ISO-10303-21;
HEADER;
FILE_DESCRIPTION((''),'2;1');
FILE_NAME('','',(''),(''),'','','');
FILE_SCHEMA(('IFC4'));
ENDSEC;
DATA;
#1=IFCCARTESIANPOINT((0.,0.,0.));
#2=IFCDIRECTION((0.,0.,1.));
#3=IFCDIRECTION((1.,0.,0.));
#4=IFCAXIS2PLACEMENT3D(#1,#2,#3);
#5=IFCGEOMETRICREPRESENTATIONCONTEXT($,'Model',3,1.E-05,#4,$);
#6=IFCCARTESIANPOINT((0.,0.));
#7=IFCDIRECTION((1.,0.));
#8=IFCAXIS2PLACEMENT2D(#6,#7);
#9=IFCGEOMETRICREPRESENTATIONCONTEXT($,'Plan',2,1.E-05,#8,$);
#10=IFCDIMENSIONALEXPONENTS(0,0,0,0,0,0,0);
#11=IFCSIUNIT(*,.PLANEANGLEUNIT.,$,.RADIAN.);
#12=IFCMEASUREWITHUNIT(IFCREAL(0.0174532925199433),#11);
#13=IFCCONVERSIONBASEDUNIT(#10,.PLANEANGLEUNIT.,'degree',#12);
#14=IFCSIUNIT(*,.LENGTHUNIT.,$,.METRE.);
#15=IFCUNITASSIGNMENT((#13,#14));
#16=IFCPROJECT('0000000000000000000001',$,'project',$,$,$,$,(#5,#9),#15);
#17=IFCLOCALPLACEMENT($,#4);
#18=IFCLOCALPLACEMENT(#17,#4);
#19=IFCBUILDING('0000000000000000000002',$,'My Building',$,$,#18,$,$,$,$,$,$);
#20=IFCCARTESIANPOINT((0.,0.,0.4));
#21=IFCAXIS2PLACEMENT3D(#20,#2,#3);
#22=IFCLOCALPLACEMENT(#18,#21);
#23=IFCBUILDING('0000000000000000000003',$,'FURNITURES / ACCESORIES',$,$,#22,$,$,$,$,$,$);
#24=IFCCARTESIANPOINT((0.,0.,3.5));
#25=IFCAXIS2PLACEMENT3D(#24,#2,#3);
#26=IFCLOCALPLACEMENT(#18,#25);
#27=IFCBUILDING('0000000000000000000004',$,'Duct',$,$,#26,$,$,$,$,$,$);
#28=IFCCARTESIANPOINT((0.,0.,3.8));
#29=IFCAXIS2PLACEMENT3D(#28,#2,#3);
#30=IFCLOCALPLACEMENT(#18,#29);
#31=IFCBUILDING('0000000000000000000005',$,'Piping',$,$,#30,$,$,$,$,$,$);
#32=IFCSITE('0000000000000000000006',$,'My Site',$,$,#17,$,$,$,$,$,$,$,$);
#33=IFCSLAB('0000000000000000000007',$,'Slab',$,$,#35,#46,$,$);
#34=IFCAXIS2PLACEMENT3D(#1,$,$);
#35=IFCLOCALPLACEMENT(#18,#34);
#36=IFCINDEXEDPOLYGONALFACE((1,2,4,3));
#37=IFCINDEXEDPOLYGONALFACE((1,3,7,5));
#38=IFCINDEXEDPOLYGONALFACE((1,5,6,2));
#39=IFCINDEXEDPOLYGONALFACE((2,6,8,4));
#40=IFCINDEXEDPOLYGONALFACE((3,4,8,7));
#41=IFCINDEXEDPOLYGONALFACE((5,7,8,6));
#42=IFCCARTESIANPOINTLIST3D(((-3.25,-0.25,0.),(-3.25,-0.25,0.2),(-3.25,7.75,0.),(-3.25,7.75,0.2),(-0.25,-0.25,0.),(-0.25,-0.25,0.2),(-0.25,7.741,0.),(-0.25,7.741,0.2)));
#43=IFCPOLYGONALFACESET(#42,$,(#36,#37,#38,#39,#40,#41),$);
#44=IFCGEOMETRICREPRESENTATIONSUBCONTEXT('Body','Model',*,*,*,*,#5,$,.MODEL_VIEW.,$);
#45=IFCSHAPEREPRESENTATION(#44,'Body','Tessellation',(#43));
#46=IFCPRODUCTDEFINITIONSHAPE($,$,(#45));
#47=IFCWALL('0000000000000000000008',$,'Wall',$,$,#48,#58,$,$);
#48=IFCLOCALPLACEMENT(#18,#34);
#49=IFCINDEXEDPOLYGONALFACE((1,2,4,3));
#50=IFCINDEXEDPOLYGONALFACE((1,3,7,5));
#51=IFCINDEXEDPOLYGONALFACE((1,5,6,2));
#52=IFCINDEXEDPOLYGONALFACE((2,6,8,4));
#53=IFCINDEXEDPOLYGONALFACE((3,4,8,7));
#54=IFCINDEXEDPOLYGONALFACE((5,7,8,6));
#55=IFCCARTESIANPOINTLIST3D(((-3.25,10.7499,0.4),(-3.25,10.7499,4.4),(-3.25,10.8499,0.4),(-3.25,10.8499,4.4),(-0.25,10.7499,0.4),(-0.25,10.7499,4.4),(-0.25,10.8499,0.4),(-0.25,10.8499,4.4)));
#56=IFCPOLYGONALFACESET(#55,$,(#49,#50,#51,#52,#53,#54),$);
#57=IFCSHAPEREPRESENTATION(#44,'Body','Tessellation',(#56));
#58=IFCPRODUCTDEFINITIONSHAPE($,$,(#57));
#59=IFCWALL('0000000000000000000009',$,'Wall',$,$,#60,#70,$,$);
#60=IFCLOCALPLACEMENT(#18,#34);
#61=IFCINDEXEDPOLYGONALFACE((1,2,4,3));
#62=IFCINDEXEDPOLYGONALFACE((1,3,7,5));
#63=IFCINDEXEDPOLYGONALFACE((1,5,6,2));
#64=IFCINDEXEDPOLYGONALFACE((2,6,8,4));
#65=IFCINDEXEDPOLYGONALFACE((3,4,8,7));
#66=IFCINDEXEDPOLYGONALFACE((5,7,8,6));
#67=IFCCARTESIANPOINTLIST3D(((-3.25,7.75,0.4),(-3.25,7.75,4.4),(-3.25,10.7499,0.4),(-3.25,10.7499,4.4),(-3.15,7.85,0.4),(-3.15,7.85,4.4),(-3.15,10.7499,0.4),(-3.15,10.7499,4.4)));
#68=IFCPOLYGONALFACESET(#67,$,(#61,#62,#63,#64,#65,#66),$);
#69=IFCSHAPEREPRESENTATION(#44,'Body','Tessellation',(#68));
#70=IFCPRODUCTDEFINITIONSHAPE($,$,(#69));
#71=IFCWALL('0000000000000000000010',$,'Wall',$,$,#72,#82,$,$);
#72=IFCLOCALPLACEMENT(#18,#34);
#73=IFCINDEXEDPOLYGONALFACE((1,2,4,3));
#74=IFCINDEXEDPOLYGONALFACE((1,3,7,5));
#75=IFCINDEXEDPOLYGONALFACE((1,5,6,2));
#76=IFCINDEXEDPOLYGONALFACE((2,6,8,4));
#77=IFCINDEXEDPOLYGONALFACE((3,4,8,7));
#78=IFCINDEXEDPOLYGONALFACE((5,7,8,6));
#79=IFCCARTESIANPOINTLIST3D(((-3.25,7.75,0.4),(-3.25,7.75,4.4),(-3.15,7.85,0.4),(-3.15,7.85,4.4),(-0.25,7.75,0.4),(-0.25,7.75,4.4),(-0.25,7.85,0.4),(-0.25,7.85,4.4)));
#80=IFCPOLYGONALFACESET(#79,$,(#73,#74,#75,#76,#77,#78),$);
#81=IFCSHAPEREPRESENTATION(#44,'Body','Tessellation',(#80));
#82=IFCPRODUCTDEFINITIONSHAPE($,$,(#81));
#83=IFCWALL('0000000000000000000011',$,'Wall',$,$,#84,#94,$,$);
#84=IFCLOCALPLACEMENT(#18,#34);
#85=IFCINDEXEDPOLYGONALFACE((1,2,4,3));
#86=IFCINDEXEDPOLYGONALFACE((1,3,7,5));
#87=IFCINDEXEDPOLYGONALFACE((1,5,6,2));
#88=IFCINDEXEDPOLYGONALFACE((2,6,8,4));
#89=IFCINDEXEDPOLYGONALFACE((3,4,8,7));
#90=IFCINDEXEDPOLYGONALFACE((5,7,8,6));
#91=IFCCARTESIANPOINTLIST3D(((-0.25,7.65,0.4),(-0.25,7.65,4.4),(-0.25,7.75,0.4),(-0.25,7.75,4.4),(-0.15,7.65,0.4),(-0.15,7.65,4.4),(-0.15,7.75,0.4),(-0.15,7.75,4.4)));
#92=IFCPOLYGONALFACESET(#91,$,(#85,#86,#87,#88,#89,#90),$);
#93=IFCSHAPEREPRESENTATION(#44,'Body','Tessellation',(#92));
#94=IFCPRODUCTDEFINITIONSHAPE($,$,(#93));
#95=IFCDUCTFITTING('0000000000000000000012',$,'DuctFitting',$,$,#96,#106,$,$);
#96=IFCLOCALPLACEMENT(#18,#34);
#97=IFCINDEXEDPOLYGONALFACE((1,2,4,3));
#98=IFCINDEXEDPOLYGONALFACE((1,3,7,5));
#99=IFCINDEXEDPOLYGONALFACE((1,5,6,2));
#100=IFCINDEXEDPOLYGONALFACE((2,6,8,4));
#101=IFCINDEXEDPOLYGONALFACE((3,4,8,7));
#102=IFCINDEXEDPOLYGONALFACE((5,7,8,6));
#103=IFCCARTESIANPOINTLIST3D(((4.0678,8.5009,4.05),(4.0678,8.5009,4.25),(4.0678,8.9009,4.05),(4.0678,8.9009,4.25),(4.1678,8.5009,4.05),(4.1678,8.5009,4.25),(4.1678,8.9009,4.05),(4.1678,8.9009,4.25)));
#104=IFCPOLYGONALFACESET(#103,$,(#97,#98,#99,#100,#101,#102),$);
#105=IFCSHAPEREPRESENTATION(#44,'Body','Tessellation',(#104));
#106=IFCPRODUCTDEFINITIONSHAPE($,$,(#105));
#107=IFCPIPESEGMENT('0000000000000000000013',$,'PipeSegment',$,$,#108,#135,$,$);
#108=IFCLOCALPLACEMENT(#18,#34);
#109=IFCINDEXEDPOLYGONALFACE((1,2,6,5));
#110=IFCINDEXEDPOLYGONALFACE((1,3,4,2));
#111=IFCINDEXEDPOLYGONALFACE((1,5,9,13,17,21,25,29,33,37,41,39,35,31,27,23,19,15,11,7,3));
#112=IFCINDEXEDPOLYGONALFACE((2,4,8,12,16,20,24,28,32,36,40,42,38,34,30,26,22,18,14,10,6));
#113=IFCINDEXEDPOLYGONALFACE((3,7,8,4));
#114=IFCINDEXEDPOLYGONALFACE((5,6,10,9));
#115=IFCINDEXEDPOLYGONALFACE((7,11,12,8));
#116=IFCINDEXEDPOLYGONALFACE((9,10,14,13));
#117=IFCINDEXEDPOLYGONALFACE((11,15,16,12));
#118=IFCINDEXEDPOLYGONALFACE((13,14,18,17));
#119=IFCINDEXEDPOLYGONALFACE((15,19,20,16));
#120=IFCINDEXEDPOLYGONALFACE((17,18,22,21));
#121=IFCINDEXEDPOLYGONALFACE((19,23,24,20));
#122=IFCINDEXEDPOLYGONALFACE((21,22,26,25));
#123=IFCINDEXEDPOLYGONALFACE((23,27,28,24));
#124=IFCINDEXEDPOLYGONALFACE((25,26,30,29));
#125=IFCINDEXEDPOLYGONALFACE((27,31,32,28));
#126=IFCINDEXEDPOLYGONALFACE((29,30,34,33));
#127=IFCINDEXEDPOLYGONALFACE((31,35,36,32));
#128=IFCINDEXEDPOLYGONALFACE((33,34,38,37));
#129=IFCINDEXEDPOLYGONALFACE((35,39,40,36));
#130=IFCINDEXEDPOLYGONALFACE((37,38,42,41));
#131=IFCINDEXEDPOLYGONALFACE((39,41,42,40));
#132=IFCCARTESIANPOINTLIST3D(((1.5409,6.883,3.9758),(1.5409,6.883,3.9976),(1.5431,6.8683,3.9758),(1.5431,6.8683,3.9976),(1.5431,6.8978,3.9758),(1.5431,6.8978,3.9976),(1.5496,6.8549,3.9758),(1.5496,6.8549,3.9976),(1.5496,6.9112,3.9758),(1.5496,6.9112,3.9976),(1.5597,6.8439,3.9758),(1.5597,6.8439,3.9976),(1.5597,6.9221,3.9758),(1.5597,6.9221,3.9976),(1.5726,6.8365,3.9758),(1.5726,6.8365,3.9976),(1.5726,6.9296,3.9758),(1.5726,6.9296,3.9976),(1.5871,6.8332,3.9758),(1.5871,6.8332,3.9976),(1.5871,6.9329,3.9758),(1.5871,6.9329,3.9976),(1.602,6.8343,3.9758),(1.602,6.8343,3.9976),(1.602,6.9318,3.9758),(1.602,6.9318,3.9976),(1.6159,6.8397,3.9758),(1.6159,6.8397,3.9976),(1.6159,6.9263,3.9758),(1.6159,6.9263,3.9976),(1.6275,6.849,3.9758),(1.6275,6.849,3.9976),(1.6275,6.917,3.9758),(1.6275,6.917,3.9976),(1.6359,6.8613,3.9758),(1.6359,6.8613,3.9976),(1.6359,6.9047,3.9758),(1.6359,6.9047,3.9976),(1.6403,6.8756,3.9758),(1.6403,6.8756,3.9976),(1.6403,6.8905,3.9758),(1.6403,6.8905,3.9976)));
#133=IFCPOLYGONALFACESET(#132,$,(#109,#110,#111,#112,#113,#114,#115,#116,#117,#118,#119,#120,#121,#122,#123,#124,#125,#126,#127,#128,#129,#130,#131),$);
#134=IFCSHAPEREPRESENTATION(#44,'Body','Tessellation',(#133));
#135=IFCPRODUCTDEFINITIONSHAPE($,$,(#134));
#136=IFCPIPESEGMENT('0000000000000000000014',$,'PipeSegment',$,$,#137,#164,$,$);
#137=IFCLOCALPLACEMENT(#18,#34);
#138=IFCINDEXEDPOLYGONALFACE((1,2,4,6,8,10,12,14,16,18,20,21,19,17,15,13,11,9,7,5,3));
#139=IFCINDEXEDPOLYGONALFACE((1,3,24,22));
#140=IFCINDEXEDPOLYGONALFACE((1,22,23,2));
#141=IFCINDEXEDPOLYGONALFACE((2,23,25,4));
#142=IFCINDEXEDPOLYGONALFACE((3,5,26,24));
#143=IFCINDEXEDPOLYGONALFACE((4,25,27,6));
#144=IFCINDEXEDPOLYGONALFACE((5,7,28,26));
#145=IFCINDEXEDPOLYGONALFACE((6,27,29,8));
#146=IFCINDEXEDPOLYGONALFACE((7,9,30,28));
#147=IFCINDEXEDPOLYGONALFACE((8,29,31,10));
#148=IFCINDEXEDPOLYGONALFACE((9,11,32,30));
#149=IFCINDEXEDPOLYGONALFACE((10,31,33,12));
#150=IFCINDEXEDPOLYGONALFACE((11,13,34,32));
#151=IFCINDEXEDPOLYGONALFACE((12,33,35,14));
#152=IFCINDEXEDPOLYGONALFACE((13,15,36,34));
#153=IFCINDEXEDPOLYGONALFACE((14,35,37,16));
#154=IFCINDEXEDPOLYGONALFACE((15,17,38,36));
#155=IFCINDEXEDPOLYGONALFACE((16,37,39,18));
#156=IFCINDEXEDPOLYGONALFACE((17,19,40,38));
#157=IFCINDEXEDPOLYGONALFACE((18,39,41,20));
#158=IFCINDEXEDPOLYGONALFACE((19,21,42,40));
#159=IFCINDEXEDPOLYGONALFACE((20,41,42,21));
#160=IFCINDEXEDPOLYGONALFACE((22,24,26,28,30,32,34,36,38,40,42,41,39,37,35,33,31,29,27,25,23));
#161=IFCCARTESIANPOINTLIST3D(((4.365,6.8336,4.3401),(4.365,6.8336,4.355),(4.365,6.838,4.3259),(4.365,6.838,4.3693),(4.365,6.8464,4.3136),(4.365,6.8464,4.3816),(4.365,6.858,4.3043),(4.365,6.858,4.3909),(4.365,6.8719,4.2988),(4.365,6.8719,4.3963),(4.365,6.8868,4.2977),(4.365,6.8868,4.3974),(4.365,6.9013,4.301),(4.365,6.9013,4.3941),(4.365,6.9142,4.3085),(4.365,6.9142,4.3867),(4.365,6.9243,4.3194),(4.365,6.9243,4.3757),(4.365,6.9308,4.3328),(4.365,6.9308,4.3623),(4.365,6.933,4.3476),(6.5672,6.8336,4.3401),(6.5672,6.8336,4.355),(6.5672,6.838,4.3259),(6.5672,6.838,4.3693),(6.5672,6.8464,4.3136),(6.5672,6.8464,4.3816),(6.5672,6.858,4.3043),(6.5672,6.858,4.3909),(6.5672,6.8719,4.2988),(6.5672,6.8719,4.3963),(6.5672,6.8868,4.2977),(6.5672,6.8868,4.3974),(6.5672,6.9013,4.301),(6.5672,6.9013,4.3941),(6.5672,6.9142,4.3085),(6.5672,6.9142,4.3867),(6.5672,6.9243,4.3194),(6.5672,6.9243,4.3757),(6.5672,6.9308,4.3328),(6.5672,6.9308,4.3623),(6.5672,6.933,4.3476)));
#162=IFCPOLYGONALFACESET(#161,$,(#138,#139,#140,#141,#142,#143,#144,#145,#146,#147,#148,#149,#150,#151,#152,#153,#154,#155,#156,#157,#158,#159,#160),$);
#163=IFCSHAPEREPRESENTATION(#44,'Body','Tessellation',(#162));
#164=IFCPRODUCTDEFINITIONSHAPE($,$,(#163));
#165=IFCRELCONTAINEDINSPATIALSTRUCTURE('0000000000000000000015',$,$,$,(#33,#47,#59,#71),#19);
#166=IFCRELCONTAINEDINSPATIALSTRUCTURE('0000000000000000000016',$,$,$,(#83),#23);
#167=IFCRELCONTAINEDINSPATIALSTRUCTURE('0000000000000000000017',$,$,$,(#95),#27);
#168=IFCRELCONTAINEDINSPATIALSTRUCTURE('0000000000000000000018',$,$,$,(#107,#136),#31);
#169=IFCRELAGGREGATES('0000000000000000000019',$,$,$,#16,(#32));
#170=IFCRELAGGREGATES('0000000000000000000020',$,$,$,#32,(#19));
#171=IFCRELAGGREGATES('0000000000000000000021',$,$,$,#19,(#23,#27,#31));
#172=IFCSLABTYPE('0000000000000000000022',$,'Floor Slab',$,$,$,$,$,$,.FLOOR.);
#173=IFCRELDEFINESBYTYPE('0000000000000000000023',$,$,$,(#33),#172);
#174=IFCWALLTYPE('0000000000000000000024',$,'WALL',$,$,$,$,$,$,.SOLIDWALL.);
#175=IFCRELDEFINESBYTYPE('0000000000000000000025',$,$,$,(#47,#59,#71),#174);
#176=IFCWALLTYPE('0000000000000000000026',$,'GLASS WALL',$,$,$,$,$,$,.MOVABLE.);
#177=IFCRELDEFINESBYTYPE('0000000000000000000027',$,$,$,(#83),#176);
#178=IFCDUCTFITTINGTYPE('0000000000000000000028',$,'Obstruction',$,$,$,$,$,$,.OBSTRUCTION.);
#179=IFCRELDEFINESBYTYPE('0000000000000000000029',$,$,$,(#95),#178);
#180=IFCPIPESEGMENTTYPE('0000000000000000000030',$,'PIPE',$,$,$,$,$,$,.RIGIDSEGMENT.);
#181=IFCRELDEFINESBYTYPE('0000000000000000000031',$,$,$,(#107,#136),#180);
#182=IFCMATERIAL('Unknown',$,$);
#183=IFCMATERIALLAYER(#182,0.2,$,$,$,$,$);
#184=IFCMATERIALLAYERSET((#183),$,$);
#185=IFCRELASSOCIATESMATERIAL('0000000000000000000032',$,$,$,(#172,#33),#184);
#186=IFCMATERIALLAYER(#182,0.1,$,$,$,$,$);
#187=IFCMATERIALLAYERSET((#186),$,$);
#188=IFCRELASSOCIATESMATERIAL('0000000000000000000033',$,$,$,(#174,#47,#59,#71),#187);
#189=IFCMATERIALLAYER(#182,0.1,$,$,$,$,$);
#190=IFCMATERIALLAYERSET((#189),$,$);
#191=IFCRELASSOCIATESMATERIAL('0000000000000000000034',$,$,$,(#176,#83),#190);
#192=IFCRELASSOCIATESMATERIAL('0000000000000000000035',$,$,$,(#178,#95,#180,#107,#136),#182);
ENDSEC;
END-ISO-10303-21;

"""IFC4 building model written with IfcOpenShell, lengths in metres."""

from ifc_helpers import new_model, entity, si_unit, converted_unit, frame, origin_with_axes, origin_2d_with_axis, place, context, subcontext, project, spatial, line, indexed_curve, rectangle, circle, outline, extrude, material, layer, layer_set, layer_usage, material_profile, profile_set, profile_usage, type_object, element, save


model = new_model("IFC4")

# Units and contexts
model_context = context("Model", 3, precision=1e-05, world=origin_with_axes())
plan_context = context("Plan", 2, precision=1e-05, world=origin_2d_with_axis())
body_context = subcontext(model_context, "Body", "Model", "MODEL_VIEW")
ifc_project = project(units=[converted_unit("PLANEANGLEUNIT", "degree", entity("IfcReal", 0.0174532925199433), si_unit("PLANEANGLEUNIT", "RADIAN"), dimensions=[0, 0, 0, 0, 0, 0, 0]), si_unit("LENGTHUNIT", "METRE")], contexts=[model_context, plan_context])

# Site, building
site_placement = place(None, origin_with_axes())
site = spatial("IfcSite", under=ifc_project, at=site_placement, Name="My Site")
building_1_placement = place(site_placement, origin_with_axes())
building_1 = spatial("IfcBuilding", under=site, at=building_1_placement, Name="My Building")

# Slab
ifc_material = material(Name="Unknown")
ifc_layer_1 = layer(ifc_material, 0.2)
ifc_layer_set_1 = layer_set([ifc_layer_1])
ifc_layer_usage_1 = layer_usage(ifc_layer_set_1, "AXIS3", "POSITIVE", -0.2)
slab_type = type_object("IfcSlabType", Name="Floor Slab", PredefinedType="FLOOR", material=ifc_layer_set_1)
slab_placement = place(building_1_placement, frame((-3.25, 7.75, 0.2), z_axis=(0.0, 0.0, 1.0), x_axis=(1.0, 0.0, 0.0)))
element("IfcSlab", 1, at=slab_placement, inside=building_1, type_object=slab_type, material=ifc_layer_usage_1, Name="Slab", context=body_context, shape_type="SweptSolid", body=[
    extrude(outline(indexed_curve([(0.0, 0.0), (3.0, -0.009), (3.0, -8.0), (0.0, -8.0), (0.0, 0.0)])), frame((0.0, 0.0, -0.2), z_axis=(0.0, 0.0, 1.0), x_axis=(1.0, 0.0, 0.0)), (0.0, 0.0, 1.0), 0.2),
])

# Walls
ifc_layer_2 = layer(ifc_material, 0.1)
ifc_layer_set_2 = layer_set([ifc_layer_2])
ifc_layer_usage_2 = layer_usage(ifc_layer_set_2, "AXIS2", "POSITIVE", 0.0)
wall_type_1 = type_object("IfcWallType", Name="WALL", PredefinedType="SOLIDWALL", material=ifc_layer_set_2)
wall_1_placement = place(building_1_placement, frame((-3.25, 10.7499, 0.4), z_axis=(0.0, 0.0, 1.0), x_axis=(1.0, 0.0, 0.0)))
element("IfcWall", 2, at=wall_1_placement, inside=building_1, type_object=wall_type_1, material=ifc_layer_usage_2, Name="Wall", context=body_context, shape_type="SweptSolid", body=[
    extrude(outline(indexed_curve([(0.0, 0.0), (0.0, 0.1), (3.0, 0.1), (3.0, 0.0)], segments=[line(1, 2, 3, 4, 1)])), origin_with_axes(), (0.0, 0.0, 1.0), 4.0),
])
ifc_layer_usage_3 = layer_usage(ifc_layer_set_2, "AXIS2", "POSITIVE", 0.0)
wall_2_placement = place(building_1_placement, frame((-3.25, 10.7499, 0.4), z_axis=(0.0, 0.0, 1.0), x_axis=(0.0, -1.0, 0.0)))
element("IfcWall", 3, at=wall_2_placement, inside=building_1, type_object=wall_type_1, material=ifc_layer_usage_3, Name="Wall", context=body_context, shape_type="SweptSolid", body=[
    extrude(outline(indexed_curve([(0.0, 0.0), (0.0, 0.1), (2.8999, 0.1), (2.9999, 0.0)], segments=[line(1, 2, 3, 4, 1)])), origin_with_axes(), (0.0, 0.0, 1.0), 4.0),
])
ifc_layer_usage_4 = layer_usage(ifc_layer_set_2, "AXIS2", "POSITIVE", 0.0)
wall_3_placement = place(building_1_placement, frame((-3.25, 7.75, 0.4), z_axis=(0.0, 0.0, 1.0), x_axis=(1.0, 0.0, 0.0)))
element("IfcWall", 4, at=wall_3_placement, inside=building_1, type_object=wall_type_1, material=ifc_layer_usage_4, Name="Wall", context=body_context, shape_type="SweptSolid", body=[
    extrude(outline(indexed_curve([(0.0, 0.0), (0.1, 0.1), (3.0, 0.1), (3.0, 0.0)], segments=[line(1, 2, 3, 4, 1)])), origin_with_axes(), (0.0, 0.0, 1.0), 4.0),
])

# Shared definitions
building_2_placement = place(building_1_placement, frame((0.0, 0.0, 0.4), z_axis=(0.0, 0.0, 1.0), x_axis=(1.0, 0.0, 0.0)))
building_2 = spatial("IfcBuilding", under=building_1, at=building_2_placement, Name="FURNITURES / ACCESORIES")

# Wall
ifc_layer_3 = layer(ifc_material, 0.1)
ifc_layer_set_3 = layer_set([ifc_layer_3])
ifc_layer_usage_5 = layer_usage(ifc_layer_set_3, "AXIS2", "POSITIVE", 0.0)
wall_type_2 = type_object("IfcWallType", Name="GLASS WALL", PredefinedType="MOVABLE", material=ifc_layer_set_3)
wall_4_placement = place(building_2_placement, frame((-0.25, 7.65, 0.0), z_axis=(0.0, 0.0, 1.0), x_axis=(1.0, 0.0, 0.0)))
element("IfcWall", 5, at=wall_4_placement, inside=building_2, type_object=wall_type_2, material=ifc_layer_usage_5, Name="Wall", context=body_context, shape_type="SweptSolid", body=[
    extrude(outline(indexed_curve([(0.0, 0.0), (0.0, 0.1), (0.1, 0.1), (0.1, 0.0)], segments=[line(1, 2, 3, 4, 1)])), origin_with_axes(), (0.0, 0.0, 1.0), 4.0),
])

# Shared definitions
building_3_placement = place(building_1_placement, frame((0.0, 0.0, 3.5), z_axis=(0.0, 0.0, 1.0), x_axis=(1.0, 0.0, 0.0)))
building_3 = spatial("IfcBuilding", under=building_1, at=building_3_placement, Name="Duct")

# Duct fitting
ifc_material_profile_1 = material_profile(ifc_material, rectangle(XDim=0.4, YDim=0.2))
ifc_profile_set_1 = profile_set([ifc_material_profile_1])
ifc_profile_usage_1 = profile_usage(ifc_profile_set_1, cardinal=5)
duct_fitting_type = type_object("IfcDuctFittingType", Name="Obstruction", PredefinedType="OBSTRUCTION", material=ifc_profile_set_1)
duct_fitting_placement = place(building_3_placement, frame((4.1678, 8.7009, 0.65), z_axis=(-1.0, 0.0, 0.0), x_axis=(0.0, 1.0, 0.0)))
element("IfcDuctFitting", 6, at=duct_fitting_placement, inside=building_3, type_object=duct_fitting_type, material=ifc_profile_usage_1, Name="DuctFitting", context=body_context, shape_type="SweptSolid", body=[
    extrude(rectangle(XDim=0.4, YDim=0.2), origin_with_axes(), (0.0, 0.0, 1.0), 0.1),
])

# Shared definitions
building_4_placement = place(building_1_placement, frame((0.0, 0.0, 3.8), z_axis=(0.0, 0.0, 1.0), x_axis=(1.0, 0.0, 0.0)))
building_4 = spatial("IfcBuilding", under=building_1, at=building_4_placement, Name="Piping")

# Pipe segments
ifc_material_profile_2 = material_profile(ifc_material, circle(Radius=0.05))
ifc_profile_set_2 = profile_set([ifc_material_profile_2])
ifc_profile_usage_2 = profile_usage(ifc_profile_set_2, cardinal=5)
pipe_segment_type = type_object("IfcPipeSegmentType", Name="PIPE", PredefinedType="RIGIDSEGMENT", material=ifc_profile_set_2)
pipe_segment_1_placement = place(building_4_placement, frame((1.5909, 6.883, 0.1976), z_axis=(0.0, 0.0, -1.0), x_axis=(-1.0, 0.0, 0.0)))
element("IfcPipeSegment", 7, at=pipe_segment_1_placement, inside=building_4, type_object=pipe_segment_type, material=ifc_profile_usage_2, Name="PipeSegment", context=body_context, shape_type="SweptSolid", body=[
    extrude(circle(Radius=0.05), origin_with_axes(), (0.0, 0.0, 1.0), 0.0218),
])
ifc_profile_usage_3 = profile_usage(ifc_profile_set_2, cardinal=5)
pipe_segment_2_placement = place(building_4_placement, frame((4.365, 6.883, 0.5476), z_axis=(1.0, -0.000001, 0.000001), x_axis=(0.000001, 1.0, 0.0)))
element("IfcPipeSegment", 8, at=pipe_segment_2_placement, inside=building_4, type_object=pipe_segment_type, material=ifc_profile_usage_3, Name="PipeSegment", context=body_context, shape_type="SweptSolid", body=[
    extrude(circle(Radius=0.05), origin_with_axes(), (0.0, 0.0, 1.0), 2.2022),
])

save(model, "model.ifc")
